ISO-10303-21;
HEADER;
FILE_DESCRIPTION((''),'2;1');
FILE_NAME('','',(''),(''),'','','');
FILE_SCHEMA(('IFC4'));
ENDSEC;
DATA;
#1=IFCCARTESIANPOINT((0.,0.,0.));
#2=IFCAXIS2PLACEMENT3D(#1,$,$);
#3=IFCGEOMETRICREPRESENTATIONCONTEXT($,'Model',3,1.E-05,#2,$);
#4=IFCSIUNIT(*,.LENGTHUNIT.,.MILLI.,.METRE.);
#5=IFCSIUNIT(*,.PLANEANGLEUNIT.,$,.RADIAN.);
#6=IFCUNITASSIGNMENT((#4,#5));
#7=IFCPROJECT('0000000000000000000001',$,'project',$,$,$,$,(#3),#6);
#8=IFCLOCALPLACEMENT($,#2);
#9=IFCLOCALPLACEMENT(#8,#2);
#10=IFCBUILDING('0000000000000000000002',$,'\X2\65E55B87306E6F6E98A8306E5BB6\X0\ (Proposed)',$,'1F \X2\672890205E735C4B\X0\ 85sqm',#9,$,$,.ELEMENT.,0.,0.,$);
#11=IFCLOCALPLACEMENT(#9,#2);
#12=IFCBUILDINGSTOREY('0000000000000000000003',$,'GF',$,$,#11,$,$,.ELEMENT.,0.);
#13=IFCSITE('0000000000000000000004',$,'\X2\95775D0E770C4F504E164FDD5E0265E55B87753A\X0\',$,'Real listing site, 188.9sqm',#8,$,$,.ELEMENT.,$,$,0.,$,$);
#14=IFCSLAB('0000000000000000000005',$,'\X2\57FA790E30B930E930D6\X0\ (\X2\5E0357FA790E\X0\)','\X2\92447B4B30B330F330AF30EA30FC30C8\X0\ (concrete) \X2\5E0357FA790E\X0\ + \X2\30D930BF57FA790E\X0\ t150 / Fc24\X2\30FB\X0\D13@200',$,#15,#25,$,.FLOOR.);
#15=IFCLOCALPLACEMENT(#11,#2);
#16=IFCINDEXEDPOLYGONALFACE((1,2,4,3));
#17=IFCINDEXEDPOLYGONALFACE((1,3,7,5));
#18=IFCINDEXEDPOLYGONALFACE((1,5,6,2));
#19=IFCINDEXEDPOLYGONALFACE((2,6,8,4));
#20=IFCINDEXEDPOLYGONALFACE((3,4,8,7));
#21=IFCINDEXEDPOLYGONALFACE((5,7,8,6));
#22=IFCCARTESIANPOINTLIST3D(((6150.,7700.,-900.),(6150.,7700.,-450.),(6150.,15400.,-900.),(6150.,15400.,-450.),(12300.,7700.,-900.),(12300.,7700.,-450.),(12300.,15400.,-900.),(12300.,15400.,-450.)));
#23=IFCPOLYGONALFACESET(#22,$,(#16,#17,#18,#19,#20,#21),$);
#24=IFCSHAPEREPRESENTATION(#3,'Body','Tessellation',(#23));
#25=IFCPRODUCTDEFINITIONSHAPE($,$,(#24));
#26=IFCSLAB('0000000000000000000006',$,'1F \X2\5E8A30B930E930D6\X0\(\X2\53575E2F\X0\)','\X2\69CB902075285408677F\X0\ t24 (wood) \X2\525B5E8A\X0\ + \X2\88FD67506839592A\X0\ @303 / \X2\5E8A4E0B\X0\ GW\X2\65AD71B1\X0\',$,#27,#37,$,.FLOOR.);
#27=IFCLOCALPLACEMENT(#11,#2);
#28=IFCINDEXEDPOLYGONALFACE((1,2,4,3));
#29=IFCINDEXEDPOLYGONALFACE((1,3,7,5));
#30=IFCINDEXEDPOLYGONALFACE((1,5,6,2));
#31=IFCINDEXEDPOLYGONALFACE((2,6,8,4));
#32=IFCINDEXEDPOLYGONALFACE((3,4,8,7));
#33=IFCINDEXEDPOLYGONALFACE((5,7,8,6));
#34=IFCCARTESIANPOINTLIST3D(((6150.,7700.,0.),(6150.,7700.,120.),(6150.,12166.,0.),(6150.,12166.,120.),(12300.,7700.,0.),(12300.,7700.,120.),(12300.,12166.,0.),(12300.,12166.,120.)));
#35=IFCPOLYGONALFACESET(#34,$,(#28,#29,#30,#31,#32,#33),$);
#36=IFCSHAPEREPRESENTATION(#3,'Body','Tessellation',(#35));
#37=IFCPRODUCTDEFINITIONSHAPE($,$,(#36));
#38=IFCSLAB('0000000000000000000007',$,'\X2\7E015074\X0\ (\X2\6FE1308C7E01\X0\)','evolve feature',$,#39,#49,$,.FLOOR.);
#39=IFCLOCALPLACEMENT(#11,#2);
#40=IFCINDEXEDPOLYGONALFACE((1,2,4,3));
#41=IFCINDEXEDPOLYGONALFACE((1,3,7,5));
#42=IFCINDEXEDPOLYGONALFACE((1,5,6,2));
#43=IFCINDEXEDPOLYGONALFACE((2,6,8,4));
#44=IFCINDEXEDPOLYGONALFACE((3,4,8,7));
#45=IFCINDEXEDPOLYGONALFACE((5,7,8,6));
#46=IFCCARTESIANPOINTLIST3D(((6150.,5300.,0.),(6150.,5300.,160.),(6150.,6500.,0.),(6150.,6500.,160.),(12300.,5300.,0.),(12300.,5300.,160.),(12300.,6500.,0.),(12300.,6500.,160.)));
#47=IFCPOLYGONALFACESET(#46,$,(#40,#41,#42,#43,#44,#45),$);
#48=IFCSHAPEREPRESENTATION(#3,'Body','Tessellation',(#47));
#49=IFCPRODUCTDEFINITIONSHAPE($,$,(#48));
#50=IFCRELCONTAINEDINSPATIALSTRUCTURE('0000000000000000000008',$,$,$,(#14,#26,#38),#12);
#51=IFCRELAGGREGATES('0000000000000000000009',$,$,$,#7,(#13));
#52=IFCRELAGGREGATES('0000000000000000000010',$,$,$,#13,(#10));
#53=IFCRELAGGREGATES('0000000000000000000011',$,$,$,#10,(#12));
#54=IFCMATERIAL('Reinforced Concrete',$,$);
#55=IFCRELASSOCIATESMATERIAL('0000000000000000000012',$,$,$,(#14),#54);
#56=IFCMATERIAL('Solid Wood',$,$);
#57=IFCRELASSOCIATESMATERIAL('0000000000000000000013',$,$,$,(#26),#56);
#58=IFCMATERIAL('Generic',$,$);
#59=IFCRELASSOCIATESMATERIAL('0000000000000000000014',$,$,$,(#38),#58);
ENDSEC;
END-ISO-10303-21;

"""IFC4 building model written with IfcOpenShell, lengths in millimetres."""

from ifc_helpers import new_model, si_unit, frame, frame_2d, origin, place, context, project, spatial, rectangle, extrude, material, element, save


model = new_model("IFC4")

# Units and contexts
model_context = context("Model", 3, precision=1e-05, world=origin())
ifc_project = project(units=[si_unit("LENGTHUNIT", "METRE", prefix="MILLI"), si_unit("PLANEANGLEUNIT", "RADIAN")], contexts=[model_context])

# Site, building, storey
site_placement = place(None, origin())
site = spatial("IfcSite", under=ifc_project, at=site_placement, Name="長崎県佐世保市日宇町", ObjectType="Real listing site, 188.9sqm", CompositionType="ELEMENT", RefElevation=0.0)
building_placement = place(site_placement, origin())
building = spatial("IfcBuilding", under=site, at=building_placement, Name="日宇の潮風の家 (Proposed)", ObjectType="1F 木造平屋 85sqm", CompositionType="ELEMENT", ElevationOfRefHeight=0.0, ElevationOfTerrain=0.0)
storey_placement = place(building_placement, origin())
storey = spatial("IfcBuildingStorey", under=building, at=storey_placement, Name="GF", CompositionType="ELEMENT", Elevation=0.0)

# Slabs
ifc_material_1 = material(Name="Reinforced Concrete")
slab_1_placement = place(storey_placement, frame((3075.0, 3850.0, -450.0)))
element("IfcSlab", 1, at=slab_1_placement, inside=storey, material=ifc_material_1, Name="基礎スラブ (布基礎)", Description="鉄筋コンクリート (concrete) 布基礎 + ベタ基礎 t150 / Fc24・D13@200", PredefinedType="FLOOR", context=model_context, shape_type="SweptSolid", body=[
    extrude(rectangle(XDim=6150.0, YDim=7700.0, at=frame_2d((3075.0, 3850.0))), frame((3075.0, 3850.0, -450.0)), (0.0, 0.0, 1.0), 450.0),
])
ifc_material_2 = material(Name="Solid Wood")
slab_2_placement = place(storey_placement, frame((3075.0, 3850.0, 0.0)))
element("IfcSlab", 2, at=slab_2_placement, inside=storey, material=ifc_material_2, Name="1F 床スラブ(南帯)", Description="構造用合板 t24 (wood) 剛床 + 製材根太 @303 / 床下 GW断熱", PredefinedType="FLOOR", context=model_context, shape_type="SweptSolid", body=[
    extrude(rectangle(XDim=6150.0, YDim=4466.0, at=frame_2d((3075.0, 2233.0))), frame((3075.0, 3850.0, 0.0)), (0.0, 0.0, 1.0), 120.0),
])
ifc_material_3 = material(Name="Generic")
slab_3_placement = place(storey_placement, frame((3075.0, 2650.0, 0.0)))
element("IfcSlab", 3, at=slab_3_placement, inside=storey, material=ifc_material_3, Name="縁側 (濡れ縁)", Description="evolve feature", PredefinedType="FLOOR", context=model_context, shape_type="SweptSolid", body=[
    extrude(rectangle(XDim=6150.0, YDim=1200.0, at=frame_2d((3075.0, 600.0))), frame((3075.0, 2650.0, 0.0)), (0.0, 0.0, 1.0), 160.0),
])

save(model, "model.ifc")
